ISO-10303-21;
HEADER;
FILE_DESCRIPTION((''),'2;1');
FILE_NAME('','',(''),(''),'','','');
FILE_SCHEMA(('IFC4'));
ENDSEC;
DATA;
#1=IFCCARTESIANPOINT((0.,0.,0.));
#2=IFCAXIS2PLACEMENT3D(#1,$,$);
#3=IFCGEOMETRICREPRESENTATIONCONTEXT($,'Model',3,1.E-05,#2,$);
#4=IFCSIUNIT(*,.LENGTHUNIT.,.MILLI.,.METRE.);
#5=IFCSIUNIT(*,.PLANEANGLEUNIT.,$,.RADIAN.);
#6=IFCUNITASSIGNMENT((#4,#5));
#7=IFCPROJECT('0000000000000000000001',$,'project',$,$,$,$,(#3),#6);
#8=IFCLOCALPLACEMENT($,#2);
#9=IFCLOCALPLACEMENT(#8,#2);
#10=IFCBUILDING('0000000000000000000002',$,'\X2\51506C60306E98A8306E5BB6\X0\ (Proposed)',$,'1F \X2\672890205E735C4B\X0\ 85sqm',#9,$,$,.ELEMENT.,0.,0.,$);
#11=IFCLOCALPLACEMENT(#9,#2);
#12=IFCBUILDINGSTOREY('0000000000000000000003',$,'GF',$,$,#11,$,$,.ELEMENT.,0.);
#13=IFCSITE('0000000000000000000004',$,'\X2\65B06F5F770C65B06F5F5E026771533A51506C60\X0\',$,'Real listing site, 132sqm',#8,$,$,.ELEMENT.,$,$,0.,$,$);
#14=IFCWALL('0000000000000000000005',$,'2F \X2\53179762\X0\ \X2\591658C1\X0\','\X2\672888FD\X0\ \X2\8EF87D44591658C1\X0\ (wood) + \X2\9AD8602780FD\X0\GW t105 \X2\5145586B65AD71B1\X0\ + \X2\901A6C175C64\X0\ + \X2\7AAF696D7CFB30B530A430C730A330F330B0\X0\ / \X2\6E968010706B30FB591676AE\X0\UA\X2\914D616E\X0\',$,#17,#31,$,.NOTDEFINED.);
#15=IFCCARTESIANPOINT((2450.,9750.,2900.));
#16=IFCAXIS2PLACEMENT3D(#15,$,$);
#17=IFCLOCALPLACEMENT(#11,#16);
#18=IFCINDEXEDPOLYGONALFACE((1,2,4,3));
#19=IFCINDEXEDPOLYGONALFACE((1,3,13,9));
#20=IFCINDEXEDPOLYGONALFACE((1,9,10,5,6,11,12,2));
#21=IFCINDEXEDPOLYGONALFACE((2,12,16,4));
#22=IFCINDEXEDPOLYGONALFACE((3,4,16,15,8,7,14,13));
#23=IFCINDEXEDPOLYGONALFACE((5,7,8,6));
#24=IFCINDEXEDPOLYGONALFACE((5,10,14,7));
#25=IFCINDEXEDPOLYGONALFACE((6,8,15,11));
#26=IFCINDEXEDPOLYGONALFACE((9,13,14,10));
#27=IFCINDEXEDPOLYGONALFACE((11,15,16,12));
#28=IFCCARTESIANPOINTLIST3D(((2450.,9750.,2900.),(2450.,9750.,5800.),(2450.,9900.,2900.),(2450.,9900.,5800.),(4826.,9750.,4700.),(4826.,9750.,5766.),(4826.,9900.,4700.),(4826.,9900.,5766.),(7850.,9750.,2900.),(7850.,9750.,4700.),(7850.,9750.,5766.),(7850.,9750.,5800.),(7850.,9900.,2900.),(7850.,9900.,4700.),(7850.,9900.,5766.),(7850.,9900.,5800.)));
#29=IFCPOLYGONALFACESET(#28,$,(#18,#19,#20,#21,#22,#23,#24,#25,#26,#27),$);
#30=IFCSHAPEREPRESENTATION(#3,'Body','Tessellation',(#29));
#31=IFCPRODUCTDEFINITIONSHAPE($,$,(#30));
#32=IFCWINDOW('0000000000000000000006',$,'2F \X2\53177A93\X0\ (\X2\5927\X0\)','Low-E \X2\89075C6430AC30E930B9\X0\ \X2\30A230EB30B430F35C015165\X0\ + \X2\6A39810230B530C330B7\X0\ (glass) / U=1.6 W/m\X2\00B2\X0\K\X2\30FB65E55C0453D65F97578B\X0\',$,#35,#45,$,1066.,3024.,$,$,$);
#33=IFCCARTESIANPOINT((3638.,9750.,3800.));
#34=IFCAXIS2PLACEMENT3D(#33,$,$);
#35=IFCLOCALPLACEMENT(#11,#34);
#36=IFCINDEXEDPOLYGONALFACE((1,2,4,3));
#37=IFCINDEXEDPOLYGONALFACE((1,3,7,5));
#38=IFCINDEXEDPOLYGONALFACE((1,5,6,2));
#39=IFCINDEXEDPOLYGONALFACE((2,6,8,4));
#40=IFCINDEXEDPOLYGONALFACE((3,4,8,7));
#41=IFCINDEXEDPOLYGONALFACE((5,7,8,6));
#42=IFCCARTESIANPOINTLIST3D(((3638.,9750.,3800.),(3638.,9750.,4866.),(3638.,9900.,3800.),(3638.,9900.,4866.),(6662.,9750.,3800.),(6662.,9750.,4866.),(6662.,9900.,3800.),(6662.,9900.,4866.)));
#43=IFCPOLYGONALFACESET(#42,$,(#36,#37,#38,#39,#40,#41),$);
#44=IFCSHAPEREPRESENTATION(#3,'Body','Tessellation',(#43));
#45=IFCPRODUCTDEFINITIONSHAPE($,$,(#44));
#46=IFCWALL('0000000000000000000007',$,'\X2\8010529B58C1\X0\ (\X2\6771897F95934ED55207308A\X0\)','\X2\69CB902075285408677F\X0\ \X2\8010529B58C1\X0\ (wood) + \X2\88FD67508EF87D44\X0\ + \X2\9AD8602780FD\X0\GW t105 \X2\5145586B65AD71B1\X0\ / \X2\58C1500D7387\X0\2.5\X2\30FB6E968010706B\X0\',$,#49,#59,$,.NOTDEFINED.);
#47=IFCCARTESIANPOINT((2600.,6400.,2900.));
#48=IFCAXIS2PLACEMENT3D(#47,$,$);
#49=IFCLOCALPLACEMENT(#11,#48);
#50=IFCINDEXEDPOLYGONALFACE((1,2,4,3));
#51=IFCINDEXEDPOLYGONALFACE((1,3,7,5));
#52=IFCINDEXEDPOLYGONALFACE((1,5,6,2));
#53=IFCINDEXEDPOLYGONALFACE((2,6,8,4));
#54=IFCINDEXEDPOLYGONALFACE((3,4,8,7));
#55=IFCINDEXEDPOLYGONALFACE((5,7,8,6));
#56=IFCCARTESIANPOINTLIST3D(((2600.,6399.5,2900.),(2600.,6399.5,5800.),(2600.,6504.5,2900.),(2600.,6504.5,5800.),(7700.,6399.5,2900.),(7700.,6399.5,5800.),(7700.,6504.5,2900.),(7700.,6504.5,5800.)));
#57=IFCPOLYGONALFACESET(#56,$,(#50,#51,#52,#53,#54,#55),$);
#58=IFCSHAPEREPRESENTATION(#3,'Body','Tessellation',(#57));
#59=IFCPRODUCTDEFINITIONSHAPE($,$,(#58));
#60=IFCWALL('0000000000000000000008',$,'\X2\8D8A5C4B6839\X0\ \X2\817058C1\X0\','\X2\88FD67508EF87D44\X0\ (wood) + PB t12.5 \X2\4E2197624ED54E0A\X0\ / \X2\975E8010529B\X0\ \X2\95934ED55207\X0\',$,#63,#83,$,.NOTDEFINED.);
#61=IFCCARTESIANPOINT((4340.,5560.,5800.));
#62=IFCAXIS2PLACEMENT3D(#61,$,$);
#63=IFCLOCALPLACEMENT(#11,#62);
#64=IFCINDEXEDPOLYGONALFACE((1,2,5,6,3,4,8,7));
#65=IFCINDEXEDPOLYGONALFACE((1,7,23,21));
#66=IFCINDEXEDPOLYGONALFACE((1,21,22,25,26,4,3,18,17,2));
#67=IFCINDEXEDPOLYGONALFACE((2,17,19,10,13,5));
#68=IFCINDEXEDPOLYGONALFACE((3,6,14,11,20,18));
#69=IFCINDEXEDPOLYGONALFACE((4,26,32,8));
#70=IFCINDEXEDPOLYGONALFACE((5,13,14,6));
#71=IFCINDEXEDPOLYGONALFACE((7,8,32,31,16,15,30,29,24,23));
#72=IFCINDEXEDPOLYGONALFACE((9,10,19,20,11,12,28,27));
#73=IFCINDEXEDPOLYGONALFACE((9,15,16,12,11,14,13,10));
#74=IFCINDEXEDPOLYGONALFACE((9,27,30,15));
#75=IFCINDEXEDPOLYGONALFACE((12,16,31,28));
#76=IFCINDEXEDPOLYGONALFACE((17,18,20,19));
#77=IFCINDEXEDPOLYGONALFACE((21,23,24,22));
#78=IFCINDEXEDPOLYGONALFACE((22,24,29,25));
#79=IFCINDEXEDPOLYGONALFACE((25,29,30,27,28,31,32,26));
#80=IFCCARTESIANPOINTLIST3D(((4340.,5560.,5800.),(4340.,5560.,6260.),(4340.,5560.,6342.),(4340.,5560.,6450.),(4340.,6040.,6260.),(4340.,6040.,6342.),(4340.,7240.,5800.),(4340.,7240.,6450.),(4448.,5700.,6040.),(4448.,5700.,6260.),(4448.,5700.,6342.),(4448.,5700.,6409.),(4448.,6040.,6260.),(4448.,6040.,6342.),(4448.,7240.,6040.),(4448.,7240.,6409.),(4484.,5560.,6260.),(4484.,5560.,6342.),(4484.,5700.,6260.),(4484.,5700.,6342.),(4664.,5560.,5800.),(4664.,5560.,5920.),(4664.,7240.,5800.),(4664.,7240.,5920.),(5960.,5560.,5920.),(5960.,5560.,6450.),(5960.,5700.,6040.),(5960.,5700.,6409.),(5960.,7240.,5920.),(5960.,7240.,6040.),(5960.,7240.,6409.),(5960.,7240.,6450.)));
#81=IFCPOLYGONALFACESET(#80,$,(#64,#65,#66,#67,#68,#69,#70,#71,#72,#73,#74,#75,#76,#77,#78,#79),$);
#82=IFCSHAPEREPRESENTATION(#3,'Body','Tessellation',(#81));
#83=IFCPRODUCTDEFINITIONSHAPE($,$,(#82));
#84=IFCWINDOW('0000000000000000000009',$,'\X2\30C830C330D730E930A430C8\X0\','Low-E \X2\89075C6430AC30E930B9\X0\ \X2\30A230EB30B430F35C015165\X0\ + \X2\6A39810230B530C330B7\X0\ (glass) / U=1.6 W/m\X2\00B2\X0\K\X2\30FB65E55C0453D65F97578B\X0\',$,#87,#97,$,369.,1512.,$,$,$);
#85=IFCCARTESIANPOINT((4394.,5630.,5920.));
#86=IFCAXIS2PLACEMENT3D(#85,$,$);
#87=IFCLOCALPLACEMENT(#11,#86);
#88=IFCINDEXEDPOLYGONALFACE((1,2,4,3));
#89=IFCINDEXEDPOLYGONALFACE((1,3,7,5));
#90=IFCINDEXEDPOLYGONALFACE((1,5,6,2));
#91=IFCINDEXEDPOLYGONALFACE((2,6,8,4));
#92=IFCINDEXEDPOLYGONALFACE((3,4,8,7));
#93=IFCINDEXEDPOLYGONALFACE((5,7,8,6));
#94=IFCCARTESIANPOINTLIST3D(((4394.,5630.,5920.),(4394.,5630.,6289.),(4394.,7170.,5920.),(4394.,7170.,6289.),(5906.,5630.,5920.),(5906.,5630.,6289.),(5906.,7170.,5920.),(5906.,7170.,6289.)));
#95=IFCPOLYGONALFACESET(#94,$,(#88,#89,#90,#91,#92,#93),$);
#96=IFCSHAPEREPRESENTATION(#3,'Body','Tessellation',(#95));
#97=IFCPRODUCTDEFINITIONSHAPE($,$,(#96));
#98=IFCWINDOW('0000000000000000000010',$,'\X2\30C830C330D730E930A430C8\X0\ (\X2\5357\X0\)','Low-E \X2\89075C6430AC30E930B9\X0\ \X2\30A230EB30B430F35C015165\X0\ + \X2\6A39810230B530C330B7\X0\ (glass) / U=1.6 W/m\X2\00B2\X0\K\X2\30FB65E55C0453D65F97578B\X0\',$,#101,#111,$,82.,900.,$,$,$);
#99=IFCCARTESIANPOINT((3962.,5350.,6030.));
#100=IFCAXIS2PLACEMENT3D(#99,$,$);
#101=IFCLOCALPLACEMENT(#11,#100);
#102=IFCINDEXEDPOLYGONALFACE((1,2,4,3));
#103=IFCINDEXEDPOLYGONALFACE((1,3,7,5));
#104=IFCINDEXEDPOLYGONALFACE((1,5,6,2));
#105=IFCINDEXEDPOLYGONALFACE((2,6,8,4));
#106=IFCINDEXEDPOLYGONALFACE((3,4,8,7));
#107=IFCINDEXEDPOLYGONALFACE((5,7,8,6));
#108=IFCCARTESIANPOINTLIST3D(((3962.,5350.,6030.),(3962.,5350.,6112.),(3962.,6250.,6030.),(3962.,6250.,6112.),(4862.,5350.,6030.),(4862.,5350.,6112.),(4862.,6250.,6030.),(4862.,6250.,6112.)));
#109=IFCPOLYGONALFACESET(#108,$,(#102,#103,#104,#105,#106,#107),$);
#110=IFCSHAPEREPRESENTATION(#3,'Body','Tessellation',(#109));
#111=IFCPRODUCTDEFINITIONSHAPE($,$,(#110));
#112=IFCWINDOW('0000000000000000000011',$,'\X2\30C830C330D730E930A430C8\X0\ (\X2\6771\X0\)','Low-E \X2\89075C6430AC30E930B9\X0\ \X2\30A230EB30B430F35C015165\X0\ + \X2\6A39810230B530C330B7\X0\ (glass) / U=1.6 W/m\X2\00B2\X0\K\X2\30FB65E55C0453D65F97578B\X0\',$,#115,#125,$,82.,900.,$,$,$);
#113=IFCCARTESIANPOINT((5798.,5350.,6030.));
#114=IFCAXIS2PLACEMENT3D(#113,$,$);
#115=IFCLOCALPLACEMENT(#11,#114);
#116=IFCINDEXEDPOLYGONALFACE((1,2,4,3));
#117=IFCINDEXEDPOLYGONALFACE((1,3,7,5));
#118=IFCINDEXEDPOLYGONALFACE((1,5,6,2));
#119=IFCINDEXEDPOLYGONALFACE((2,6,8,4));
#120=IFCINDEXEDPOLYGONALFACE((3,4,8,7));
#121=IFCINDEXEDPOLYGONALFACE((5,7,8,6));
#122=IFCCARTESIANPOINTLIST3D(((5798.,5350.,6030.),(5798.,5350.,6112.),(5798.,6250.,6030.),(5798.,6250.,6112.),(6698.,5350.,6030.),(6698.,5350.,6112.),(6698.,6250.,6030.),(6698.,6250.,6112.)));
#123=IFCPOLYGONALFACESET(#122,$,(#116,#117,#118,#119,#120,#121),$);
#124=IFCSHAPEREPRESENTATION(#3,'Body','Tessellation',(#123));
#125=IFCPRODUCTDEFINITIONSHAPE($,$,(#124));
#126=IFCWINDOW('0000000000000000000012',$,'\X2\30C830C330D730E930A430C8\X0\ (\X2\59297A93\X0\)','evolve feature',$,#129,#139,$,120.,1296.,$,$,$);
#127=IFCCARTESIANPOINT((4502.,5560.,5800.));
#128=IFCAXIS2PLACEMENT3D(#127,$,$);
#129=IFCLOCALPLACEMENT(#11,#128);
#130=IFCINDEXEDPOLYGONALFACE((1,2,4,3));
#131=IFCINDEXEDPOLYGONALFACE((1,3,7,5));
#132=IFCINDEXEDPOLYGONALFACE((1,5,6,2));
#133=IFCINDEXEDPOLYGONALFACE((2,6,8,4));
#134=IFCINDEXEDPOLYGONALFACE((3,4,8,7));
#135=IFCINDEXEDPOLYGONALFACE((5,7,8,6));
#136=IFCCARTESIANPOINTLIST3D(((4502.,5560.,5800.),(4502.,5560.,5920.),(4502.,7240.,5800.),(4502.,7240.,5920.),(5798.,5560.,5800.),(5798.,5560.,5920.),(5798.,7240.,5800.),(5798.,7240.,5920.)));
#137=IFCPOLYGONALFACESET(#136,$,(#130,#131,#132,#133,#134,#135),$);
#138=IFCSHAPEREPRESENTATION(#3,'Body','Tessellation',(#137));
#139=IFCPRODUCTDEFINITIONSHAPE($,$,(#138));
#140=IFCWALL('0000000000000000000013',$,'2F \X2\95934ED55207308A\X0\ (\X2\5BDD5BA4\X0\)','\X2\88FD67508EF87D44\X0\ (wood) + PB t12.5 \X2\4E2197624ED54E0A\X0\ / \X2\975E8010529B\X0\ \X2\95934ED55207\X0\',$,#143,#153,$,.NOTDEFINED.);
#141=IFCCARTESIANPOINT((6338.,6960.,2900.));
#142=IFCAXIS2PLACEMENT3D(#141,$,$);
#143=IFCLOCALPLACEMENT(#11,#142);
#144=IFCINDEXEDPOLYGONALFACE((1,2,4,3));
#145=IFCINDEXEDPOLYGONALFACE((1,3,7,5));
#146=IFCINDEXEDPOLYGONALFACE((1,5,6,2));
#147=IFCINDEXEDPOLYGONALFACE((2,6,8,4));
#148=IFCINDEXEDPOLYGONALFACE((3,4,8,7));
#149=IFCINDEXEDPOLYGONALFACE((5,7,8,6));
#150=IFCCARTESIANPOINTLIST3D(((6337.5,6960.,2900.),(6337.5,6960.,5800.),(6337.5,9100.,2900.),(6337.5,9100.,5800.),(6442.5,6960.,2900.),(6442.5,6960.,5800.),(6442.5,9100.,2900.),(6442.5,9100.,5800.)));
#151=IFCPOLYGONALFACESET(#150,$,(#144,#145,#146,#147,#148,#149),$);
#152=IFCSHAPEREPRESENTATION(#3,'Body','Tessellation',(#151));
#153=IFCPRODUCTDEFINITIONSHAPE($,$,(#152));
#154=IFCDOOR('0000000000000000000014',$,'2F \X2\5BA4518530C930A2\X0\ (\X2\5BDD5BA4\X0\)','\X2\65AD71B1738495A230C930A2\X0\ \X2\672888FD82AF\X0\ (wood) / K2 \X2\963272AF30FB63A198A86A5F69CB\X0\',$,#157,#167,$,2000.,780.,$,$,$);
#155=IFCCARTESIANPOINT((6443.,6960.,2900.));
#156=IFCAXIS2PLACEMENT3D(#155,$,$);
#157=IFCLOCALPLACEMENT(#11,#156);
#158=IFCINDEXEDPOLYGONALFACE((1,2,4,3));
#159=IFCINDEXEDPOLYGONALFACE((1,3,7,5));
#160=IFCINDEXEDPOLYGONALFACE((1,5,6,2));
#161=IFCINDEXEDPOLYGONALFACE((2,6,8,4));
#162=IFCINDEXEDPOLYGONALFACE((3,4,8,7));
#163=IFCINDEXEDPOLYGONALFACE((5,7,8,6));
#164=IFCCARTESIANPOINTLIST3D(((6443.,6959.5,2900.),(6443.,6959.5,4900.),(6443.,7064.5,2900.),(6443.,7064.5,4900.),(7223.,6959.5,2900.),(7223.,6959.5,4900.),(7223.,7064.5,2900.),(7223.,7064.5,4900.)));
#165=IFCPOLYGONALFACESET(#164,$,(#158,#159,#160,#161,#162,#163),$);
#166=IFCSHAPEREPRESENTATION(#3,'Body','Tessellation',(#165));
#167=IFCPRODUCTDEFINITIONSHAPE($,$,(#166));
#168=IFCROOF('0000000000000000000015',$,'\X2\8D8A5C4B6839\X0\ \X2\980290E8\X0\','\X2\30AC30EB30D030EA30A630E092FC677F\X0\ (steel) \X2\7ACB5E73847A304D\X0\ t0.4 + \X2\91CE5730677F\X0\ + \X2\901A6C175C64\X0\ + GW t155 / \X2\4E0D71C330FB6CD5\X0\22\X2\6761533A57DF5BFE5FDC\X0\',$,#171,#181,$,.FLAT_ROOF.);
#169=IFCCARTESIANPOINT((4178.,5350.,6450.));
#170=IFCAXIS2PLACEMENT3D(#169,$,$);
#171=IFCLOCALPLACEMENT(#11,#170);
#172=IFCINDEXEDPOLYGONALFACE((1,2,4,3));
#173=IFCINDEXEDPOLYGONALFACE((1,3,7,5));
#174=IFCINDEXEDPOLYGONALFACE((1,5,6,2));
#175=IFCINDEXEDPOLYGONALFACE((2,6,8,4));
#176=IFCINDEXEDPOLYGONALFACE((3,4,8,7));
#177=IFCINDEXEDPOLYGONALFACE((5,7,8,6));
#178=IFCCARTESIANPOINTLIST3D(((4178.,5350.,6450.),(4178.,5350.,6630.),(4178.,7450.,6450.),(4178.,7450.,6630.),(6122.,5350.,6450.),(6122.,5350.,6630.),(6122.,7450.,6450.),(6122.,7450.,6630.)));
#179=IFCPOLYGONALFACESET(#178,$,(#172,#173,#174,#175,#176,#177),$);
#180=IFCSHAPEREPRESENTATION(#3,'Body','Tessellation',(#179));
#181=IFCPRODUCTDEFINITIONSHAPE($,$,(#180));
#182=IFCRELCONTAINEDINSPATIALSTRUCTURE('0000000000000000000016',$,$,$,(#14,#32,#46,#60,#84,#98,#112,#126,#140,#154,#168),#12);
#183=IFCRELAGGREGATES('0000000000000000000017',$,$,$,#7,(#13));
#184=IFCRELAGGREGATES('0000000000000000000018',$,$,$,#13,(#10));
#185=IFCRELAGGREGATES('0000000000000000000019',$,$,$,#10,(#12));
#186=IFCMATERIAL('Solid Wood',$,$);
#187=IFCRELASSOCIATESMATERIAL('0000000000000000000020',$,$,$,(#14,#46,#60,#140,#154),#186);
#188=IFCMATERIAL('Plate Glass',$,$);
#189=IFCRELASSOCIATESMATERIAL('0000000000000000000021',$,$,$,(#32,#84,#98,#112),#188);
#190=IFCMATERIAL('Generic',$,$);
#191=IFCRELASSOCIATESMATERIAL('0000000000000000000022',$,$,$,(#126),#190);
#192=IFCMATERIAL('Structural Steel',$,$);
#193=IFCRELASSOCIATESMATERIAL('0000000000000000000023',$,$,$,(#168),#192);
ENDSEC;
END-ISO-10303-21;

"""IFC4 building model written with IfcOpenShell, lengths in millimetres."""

from ifc_helpers import new_model, si_unit, frame, frame_2d, origin, place, context, project, spatial, rectangle, extrude, material, element, fill, save


model = new_model("IFC4")

# Units and contexts
model_context = context("Model", 3, precision=1e-05, world=origin())
ifc_project = project(units=[si_unit("LENGTHUNIT", "METRE", prefix="MILLI"), si_unit("PLANEANGLEUNIT", "RADIAN")], contexts=[model_context])

# Site, building, storey
site_placement = place(None, origin())
site = spatial("IfcSite", under=ifc_project, at=site_placement, Name="新潟県新潟市東区児池", ObjectType="Real listing site, 132sqm", CompositionType="ELEMENT", RefElevation=0.0)
building_placement = place(site_placement, origin())
building = spatial("IfcBuilding", under=site, at=building_placement, Name="児池の風の家 (Proposed)", ObjectType="1F 木造平屋 85sqm", CompositionType="ELEMENT", ElevationOfRefHeight=0.0, ElevationOfTerrain=0.0)
storey_placement = place(building_placement, origin())
storey = spatial("IfcBuildingStorey", under=building, at=storey_placement, Name="GF", CompositionType="ELEMENT", Elevation=0.0)

# Wall, opening, window
ifc_material_1 = material(Name="Solid Wood")
wall_1_placement = place(storey_placement, frame((2450.0, 9750.0, 2900.0)))
wall_1 = element("IfcWall", 1, at=wall_1_placement, inside=storey, material=ifc_material_1, Name="2F 北面 外壁", Description="木製 軸組外壁 (wood) + 高性能GW t105 充填断熱 + 通気層 + 窯業系サイディング / 準耐火・外皮UA配慮", PredefinedType="NOTDEFINED", context=model_context, shape_type="SweptSolid", body=[
    extrude(rectangle(XDim=5400.0, YDim=150.0, at=frame_2d((2700.0, 75.0))), frame((2450.0, 9750.0, 2900.0)), (0.0, 0.0, 1.0), 2900.0),
])
opening_1_placement = place(storey_placement, frame((3638.0, 9750.0, 3800.0)))
opening_1 = element("IfcOpeningElement", 2, at=opening_1_placement, cuts=wall_1, PredefinedType="NOTDEFINED", context=model_context, shape_type="SweptSolid", body=[
    extrude(rectangle(XDim=3024.0, YDim=150.0, at=frame_2d((1512.0, 75.0))), frame((3638.0, 9750.0, 3800.0)), (0.0, 0.0, 1.0), 1066.0),
])
ifc_material_2 = material(Name="Plate Glass")
window_1_placement = place(storey_placement, frame((3638.0, 9750.0, 3800.0)))
window_1 = element("IfcWindow", 3, at=window_1_placement, inside=storey, material=ifc_material_2, Name="2F 北窓 (大)", Description="Low-E 複層ガラス アルゴン封入 + 樹脂サッシ (glass) / U=1.6 W/m²K・日射取得型", OverallHeight=1066.0, OverallWidth=3024.0, context=model_context, shape_type="SweptSolid", body=[
    extrude(rectangle(XDim=3024.0, YDim=150.0, at=frame_2d((1512.0, 75.0))), frame((3638.0, 9750.0, 3800.0)), (0.0, 0.0, 1.0), 1066.0),
])
fill(opening_1, window_1)

# Wall
wall_2_placement = place(storey_placement, frame((2600.0, 6400.0, 2900.0)))
element("IfcWall", 4, at=wall_2_placement, inside=storey, material=ifc_material_1, Name="耐力壁 (東西間仕切り)", Description="構造用合板 耐力壁 (wood) + 製材軸組 + 高性能GW t105 充填断熱 / 壁倍率2.5・準耐火", PredefinedType="NOTDEFINED", context=model_context, shape_type="SweptSolid", body=[
    extrude(rectangle(XDim=5100.0, YDim=105.0, at=frame_2d((2550.0, 52.0))), frame((2600.0, 6400.0, 2900.0)), (0.0, 0.0, 1.0), 2900.0),
])

# Wall, openings, windows
wall_3_placement = place(storey_placement, frame((4340.0, 5560.0, 5800.0)))
wall_3 = element("IfcWall", 5, at=wall_3_placement, inside=storey, material=ifc_material_1, Name="越屋根 腰壁", Description="製材軸組 (wood) + PB t12.5 両面仕上 / 非耐力 間仕切", PredefinedType="NOTDEFINED", context=model_context, shape_type="SweptSolid", body=[
    extrude(rectangle(XDim=1620.0, YDim=1680.0, at=frame_2d((810.0, 840.0))), frame((4340.0, 5560.0, 5800.0)), (0.0, 0.0, 1.0), 650.0),
])
opening_2_placement = place(storey_placement, frame((4394.0, 5630.0, 5920.0)))
opening_2 = element("IfcOpeningElement", 6, at=opening_2_placement, cuts=wall_3, PredefinedType="NOTDEFINED", context=model_context, shape_type="SweptSolid", body=[
    extrude(rectangle(XDim=1512.0, YDim=1540.0, at=frame_2d((756.0, 770.0))), frame((4394.0, 5630.0, 5920.0)), (0.0, 0.0, 1.0), 369.0),
])
opening_3_placement = place(storey_placement, frame((3962.0, 5350.0, 6030.0)))
opening_3 = element("IfcOpeningElement", 7, at=opening_3_placement, cuts=wall_3, PredefinedType="NOTDEFINED", context=model_context, shape_type="SweptSolid", body=[
    extrude(rectangle(XDim=900.0, YDim=900.0, at=frame_2d((450.0, 450.0))), frame((3962.0, 5350.0, 6030.0)), (0.0, 0.0, 1.0), 82.0),
])
opening_4_placement = place(storey_placement, frame((5798.0, 5350.0, 6030.0)))
opening_4 = element("IfcOpeningElement", 8, at=opening_4_placement, cuts=wall_3, PredefinedType="NOTDEFINED", context=model_context, shape_type="SweptSolid", body=[
    extrude(rectangle(XDim=900.0, YDim=900.0, at=frame_2d((450.0, 450.0))), frame((5798.0, 5350.0, 6030.0)), (0.0, 0.0, 1.0), 82.0),
])
opening_5_placement = place(storey_placement, frame((4502.0, 5560.0, 5800.0)))
opening_5 = element("IfcOpeningElement", 9, at=opening_5_placement, cuts=wall_3, PredefinedType="NOTDEFINED", context=model_context, shape_type="SweptSolid", body=[
    extrude(rectangle(XDim=1296.0, YDim=1680.0, at=frame_2d((648.0, 840.0))), frame((4502.0, 5560.0, 5800.0)), (0.0, 0.0, 1.0), 120.0),
])
window_2_placement = place(storey_placement, frame((4394.0, 5630.0, 5920.0)))
window_2 = element("IfcWindow", 10, at=window_2_placement, inside=storey, material=ifc_material_2, Name="トップライト", Description="Low-E 複層ガラス アルゴン封入 + 樹脂サッシ (glass) / U=1.6 W/m²K・日射取得型", OverallHeight=369.0, OverallWidth=1512.0, context=model_context, shape_type="SweptSolid", body=[
    extrude(rectangle(XDim=1512.0, YDim=1540.0, at=frame_2d((756.0, 770.0))), frame((4394.0, 5630.0, 5920.0)), (0.0, 0.0, 1.0), 369.0),
])
fill(opening_2, window_2)
window_3_placement = place(storey_placement, frame((3962.0, 5350.0, 6030.0)))
window_3 = element("IfcWindow", 11, at=window_3_placement, inside=storey, material=ifc_material_2, Name="トップライト (南)", Description="Low-E 複層ガラス アルゴン封入 + 樹脂サッシ (glass) / U=1.6 W/m²K・日射取得型", OverallHeight=82.0, OverallWidth=900.0, context=model_context, shape_type="SweptSolid", body=[
    extrude(rectangle(XDim=900.0, YDim=900.0, at=frame_2d((450.0, 450.0))), frame((3962.0, 5350.0, 6030.0)), (0.0, 0.0, 1.0), 82.0),
])
fill(opening_3, window_3)
window_4_placement = place(storey_placement, frame((5798.0, 5350.0, 6030.0)))
window_4 = element("IfcWindow", 12, at=window_4_placement, inside=storey, material=ifc_material_2, Name="トップライト (東)", Description="Low-E 複層ガラス アルゴン封入 + 樹脂サッシ (glass) / U=1.6 W/m²K・日射取得型", OverallHeight=82.0, OverallWidth=900.0, context=model_context, shape_type="SweptSolid", body=[
    extrude(rectangle(XDim=900.0, YDim=900.0, at=frame_2d((450.0, 450.0))), frame((5798.0, 5350.0, 6030.0)), (0.0, 0.0, 1.0), 82.0),
])
fill(opening_4, window_4)
ifc_material_3 = material(Name="Generic")
window_5_placement = place(storey_placement, frame((4502.0, 5560.0, 5800.0)))
window_5 = element("IfcWindow", 13, at=window_5_placement, inside=storey, material=ifc_material_3, Name="トップライト (天窓)", Description="evolve feature", OverallHeight=120.0, OverallWidth=1296.0, context=model_context, shape_type="SweptSolid", body=[
    extrude(rectangle(XDim=1296.0, YDim=1680.0, at=frame_2d((648.0, 840.0))), frame((4502.0, 5560.0, 5800.0)), (0.0, 0.0, 1.0), 120.0),
])
fill(opening_5, window_5)

# Wall
wall_4_placement = place(storey_placement, frame((6338.0, 6960.0, 2900.0)))
element("IfcWall", 14, at=wall_4_placement, inside=storey, material=ifc_material_1, Name="2F 間仕切り (寝室)", Description="製材軸組 (wood) + PB t12.5 両面仕上 / 非耐力 間仕切", PredefinedType="NOTDEFINED", context=model_context, shape_type="SweptSolid", body=[
    extrude(rectangle(XDim=105.0, YDim=2140.0, at=frame_2d((52.0, 1070.0))), frame((6338.0, 6960.0, 2900.0)), (0.0, 0.0, 1.0), 2900.0),
])

# Door
door_placement = place(storey_placement, frame((6443.0, 6960.0, 2900.0)))
element("IfcDoor", 15, at=door_placement, inside=storey, material=ifc_material_1, Name="2F 室内ドア (寝室)", Description="断熱玄関ドア 木製芯 (wood) / K2 防犯・採風機構", OverallHeight=2000.0, OverallWidth=780.0, context=model_context, shape_type="SweptSolid", body=[
    extrude(rectangle(XDim=780.0, YDim=105.0, at=frame_2d((390.0, 52.0))), frame((6443.0, 6960.0, 2900.0)), (0.0, 0.0, 1.0), 2000.0),
])

# Roof
ifc_material_4 = material(Name="Structural Steel")
roof_placement = place(storey_placement, frame((4178.0, 5350.0, 6450.0)))
element("IfcRoof", 16, at=roof_placement, inside=storey, material=ifc_material_4, Name="越屋根 頂部", Description="ガルバリウム鋼板 (steel) 立平葺き t0.4 + 野地板 + 通気層 + GW t155 / 不燃・法22条区域対応", PredefinedType="FLAT_ROOF", context=model_context, shape_type="SweptSolid", body=[
    extrude(rectangle(XDim=1944.0, YDim=2100.0, at=frame_2d((972.0, 1050.0))), frame((4178.0, 5350.0, 6450.0)), (0.0, 0.0, 1.0), 180.0),
])

save(model, "model.ifc")
